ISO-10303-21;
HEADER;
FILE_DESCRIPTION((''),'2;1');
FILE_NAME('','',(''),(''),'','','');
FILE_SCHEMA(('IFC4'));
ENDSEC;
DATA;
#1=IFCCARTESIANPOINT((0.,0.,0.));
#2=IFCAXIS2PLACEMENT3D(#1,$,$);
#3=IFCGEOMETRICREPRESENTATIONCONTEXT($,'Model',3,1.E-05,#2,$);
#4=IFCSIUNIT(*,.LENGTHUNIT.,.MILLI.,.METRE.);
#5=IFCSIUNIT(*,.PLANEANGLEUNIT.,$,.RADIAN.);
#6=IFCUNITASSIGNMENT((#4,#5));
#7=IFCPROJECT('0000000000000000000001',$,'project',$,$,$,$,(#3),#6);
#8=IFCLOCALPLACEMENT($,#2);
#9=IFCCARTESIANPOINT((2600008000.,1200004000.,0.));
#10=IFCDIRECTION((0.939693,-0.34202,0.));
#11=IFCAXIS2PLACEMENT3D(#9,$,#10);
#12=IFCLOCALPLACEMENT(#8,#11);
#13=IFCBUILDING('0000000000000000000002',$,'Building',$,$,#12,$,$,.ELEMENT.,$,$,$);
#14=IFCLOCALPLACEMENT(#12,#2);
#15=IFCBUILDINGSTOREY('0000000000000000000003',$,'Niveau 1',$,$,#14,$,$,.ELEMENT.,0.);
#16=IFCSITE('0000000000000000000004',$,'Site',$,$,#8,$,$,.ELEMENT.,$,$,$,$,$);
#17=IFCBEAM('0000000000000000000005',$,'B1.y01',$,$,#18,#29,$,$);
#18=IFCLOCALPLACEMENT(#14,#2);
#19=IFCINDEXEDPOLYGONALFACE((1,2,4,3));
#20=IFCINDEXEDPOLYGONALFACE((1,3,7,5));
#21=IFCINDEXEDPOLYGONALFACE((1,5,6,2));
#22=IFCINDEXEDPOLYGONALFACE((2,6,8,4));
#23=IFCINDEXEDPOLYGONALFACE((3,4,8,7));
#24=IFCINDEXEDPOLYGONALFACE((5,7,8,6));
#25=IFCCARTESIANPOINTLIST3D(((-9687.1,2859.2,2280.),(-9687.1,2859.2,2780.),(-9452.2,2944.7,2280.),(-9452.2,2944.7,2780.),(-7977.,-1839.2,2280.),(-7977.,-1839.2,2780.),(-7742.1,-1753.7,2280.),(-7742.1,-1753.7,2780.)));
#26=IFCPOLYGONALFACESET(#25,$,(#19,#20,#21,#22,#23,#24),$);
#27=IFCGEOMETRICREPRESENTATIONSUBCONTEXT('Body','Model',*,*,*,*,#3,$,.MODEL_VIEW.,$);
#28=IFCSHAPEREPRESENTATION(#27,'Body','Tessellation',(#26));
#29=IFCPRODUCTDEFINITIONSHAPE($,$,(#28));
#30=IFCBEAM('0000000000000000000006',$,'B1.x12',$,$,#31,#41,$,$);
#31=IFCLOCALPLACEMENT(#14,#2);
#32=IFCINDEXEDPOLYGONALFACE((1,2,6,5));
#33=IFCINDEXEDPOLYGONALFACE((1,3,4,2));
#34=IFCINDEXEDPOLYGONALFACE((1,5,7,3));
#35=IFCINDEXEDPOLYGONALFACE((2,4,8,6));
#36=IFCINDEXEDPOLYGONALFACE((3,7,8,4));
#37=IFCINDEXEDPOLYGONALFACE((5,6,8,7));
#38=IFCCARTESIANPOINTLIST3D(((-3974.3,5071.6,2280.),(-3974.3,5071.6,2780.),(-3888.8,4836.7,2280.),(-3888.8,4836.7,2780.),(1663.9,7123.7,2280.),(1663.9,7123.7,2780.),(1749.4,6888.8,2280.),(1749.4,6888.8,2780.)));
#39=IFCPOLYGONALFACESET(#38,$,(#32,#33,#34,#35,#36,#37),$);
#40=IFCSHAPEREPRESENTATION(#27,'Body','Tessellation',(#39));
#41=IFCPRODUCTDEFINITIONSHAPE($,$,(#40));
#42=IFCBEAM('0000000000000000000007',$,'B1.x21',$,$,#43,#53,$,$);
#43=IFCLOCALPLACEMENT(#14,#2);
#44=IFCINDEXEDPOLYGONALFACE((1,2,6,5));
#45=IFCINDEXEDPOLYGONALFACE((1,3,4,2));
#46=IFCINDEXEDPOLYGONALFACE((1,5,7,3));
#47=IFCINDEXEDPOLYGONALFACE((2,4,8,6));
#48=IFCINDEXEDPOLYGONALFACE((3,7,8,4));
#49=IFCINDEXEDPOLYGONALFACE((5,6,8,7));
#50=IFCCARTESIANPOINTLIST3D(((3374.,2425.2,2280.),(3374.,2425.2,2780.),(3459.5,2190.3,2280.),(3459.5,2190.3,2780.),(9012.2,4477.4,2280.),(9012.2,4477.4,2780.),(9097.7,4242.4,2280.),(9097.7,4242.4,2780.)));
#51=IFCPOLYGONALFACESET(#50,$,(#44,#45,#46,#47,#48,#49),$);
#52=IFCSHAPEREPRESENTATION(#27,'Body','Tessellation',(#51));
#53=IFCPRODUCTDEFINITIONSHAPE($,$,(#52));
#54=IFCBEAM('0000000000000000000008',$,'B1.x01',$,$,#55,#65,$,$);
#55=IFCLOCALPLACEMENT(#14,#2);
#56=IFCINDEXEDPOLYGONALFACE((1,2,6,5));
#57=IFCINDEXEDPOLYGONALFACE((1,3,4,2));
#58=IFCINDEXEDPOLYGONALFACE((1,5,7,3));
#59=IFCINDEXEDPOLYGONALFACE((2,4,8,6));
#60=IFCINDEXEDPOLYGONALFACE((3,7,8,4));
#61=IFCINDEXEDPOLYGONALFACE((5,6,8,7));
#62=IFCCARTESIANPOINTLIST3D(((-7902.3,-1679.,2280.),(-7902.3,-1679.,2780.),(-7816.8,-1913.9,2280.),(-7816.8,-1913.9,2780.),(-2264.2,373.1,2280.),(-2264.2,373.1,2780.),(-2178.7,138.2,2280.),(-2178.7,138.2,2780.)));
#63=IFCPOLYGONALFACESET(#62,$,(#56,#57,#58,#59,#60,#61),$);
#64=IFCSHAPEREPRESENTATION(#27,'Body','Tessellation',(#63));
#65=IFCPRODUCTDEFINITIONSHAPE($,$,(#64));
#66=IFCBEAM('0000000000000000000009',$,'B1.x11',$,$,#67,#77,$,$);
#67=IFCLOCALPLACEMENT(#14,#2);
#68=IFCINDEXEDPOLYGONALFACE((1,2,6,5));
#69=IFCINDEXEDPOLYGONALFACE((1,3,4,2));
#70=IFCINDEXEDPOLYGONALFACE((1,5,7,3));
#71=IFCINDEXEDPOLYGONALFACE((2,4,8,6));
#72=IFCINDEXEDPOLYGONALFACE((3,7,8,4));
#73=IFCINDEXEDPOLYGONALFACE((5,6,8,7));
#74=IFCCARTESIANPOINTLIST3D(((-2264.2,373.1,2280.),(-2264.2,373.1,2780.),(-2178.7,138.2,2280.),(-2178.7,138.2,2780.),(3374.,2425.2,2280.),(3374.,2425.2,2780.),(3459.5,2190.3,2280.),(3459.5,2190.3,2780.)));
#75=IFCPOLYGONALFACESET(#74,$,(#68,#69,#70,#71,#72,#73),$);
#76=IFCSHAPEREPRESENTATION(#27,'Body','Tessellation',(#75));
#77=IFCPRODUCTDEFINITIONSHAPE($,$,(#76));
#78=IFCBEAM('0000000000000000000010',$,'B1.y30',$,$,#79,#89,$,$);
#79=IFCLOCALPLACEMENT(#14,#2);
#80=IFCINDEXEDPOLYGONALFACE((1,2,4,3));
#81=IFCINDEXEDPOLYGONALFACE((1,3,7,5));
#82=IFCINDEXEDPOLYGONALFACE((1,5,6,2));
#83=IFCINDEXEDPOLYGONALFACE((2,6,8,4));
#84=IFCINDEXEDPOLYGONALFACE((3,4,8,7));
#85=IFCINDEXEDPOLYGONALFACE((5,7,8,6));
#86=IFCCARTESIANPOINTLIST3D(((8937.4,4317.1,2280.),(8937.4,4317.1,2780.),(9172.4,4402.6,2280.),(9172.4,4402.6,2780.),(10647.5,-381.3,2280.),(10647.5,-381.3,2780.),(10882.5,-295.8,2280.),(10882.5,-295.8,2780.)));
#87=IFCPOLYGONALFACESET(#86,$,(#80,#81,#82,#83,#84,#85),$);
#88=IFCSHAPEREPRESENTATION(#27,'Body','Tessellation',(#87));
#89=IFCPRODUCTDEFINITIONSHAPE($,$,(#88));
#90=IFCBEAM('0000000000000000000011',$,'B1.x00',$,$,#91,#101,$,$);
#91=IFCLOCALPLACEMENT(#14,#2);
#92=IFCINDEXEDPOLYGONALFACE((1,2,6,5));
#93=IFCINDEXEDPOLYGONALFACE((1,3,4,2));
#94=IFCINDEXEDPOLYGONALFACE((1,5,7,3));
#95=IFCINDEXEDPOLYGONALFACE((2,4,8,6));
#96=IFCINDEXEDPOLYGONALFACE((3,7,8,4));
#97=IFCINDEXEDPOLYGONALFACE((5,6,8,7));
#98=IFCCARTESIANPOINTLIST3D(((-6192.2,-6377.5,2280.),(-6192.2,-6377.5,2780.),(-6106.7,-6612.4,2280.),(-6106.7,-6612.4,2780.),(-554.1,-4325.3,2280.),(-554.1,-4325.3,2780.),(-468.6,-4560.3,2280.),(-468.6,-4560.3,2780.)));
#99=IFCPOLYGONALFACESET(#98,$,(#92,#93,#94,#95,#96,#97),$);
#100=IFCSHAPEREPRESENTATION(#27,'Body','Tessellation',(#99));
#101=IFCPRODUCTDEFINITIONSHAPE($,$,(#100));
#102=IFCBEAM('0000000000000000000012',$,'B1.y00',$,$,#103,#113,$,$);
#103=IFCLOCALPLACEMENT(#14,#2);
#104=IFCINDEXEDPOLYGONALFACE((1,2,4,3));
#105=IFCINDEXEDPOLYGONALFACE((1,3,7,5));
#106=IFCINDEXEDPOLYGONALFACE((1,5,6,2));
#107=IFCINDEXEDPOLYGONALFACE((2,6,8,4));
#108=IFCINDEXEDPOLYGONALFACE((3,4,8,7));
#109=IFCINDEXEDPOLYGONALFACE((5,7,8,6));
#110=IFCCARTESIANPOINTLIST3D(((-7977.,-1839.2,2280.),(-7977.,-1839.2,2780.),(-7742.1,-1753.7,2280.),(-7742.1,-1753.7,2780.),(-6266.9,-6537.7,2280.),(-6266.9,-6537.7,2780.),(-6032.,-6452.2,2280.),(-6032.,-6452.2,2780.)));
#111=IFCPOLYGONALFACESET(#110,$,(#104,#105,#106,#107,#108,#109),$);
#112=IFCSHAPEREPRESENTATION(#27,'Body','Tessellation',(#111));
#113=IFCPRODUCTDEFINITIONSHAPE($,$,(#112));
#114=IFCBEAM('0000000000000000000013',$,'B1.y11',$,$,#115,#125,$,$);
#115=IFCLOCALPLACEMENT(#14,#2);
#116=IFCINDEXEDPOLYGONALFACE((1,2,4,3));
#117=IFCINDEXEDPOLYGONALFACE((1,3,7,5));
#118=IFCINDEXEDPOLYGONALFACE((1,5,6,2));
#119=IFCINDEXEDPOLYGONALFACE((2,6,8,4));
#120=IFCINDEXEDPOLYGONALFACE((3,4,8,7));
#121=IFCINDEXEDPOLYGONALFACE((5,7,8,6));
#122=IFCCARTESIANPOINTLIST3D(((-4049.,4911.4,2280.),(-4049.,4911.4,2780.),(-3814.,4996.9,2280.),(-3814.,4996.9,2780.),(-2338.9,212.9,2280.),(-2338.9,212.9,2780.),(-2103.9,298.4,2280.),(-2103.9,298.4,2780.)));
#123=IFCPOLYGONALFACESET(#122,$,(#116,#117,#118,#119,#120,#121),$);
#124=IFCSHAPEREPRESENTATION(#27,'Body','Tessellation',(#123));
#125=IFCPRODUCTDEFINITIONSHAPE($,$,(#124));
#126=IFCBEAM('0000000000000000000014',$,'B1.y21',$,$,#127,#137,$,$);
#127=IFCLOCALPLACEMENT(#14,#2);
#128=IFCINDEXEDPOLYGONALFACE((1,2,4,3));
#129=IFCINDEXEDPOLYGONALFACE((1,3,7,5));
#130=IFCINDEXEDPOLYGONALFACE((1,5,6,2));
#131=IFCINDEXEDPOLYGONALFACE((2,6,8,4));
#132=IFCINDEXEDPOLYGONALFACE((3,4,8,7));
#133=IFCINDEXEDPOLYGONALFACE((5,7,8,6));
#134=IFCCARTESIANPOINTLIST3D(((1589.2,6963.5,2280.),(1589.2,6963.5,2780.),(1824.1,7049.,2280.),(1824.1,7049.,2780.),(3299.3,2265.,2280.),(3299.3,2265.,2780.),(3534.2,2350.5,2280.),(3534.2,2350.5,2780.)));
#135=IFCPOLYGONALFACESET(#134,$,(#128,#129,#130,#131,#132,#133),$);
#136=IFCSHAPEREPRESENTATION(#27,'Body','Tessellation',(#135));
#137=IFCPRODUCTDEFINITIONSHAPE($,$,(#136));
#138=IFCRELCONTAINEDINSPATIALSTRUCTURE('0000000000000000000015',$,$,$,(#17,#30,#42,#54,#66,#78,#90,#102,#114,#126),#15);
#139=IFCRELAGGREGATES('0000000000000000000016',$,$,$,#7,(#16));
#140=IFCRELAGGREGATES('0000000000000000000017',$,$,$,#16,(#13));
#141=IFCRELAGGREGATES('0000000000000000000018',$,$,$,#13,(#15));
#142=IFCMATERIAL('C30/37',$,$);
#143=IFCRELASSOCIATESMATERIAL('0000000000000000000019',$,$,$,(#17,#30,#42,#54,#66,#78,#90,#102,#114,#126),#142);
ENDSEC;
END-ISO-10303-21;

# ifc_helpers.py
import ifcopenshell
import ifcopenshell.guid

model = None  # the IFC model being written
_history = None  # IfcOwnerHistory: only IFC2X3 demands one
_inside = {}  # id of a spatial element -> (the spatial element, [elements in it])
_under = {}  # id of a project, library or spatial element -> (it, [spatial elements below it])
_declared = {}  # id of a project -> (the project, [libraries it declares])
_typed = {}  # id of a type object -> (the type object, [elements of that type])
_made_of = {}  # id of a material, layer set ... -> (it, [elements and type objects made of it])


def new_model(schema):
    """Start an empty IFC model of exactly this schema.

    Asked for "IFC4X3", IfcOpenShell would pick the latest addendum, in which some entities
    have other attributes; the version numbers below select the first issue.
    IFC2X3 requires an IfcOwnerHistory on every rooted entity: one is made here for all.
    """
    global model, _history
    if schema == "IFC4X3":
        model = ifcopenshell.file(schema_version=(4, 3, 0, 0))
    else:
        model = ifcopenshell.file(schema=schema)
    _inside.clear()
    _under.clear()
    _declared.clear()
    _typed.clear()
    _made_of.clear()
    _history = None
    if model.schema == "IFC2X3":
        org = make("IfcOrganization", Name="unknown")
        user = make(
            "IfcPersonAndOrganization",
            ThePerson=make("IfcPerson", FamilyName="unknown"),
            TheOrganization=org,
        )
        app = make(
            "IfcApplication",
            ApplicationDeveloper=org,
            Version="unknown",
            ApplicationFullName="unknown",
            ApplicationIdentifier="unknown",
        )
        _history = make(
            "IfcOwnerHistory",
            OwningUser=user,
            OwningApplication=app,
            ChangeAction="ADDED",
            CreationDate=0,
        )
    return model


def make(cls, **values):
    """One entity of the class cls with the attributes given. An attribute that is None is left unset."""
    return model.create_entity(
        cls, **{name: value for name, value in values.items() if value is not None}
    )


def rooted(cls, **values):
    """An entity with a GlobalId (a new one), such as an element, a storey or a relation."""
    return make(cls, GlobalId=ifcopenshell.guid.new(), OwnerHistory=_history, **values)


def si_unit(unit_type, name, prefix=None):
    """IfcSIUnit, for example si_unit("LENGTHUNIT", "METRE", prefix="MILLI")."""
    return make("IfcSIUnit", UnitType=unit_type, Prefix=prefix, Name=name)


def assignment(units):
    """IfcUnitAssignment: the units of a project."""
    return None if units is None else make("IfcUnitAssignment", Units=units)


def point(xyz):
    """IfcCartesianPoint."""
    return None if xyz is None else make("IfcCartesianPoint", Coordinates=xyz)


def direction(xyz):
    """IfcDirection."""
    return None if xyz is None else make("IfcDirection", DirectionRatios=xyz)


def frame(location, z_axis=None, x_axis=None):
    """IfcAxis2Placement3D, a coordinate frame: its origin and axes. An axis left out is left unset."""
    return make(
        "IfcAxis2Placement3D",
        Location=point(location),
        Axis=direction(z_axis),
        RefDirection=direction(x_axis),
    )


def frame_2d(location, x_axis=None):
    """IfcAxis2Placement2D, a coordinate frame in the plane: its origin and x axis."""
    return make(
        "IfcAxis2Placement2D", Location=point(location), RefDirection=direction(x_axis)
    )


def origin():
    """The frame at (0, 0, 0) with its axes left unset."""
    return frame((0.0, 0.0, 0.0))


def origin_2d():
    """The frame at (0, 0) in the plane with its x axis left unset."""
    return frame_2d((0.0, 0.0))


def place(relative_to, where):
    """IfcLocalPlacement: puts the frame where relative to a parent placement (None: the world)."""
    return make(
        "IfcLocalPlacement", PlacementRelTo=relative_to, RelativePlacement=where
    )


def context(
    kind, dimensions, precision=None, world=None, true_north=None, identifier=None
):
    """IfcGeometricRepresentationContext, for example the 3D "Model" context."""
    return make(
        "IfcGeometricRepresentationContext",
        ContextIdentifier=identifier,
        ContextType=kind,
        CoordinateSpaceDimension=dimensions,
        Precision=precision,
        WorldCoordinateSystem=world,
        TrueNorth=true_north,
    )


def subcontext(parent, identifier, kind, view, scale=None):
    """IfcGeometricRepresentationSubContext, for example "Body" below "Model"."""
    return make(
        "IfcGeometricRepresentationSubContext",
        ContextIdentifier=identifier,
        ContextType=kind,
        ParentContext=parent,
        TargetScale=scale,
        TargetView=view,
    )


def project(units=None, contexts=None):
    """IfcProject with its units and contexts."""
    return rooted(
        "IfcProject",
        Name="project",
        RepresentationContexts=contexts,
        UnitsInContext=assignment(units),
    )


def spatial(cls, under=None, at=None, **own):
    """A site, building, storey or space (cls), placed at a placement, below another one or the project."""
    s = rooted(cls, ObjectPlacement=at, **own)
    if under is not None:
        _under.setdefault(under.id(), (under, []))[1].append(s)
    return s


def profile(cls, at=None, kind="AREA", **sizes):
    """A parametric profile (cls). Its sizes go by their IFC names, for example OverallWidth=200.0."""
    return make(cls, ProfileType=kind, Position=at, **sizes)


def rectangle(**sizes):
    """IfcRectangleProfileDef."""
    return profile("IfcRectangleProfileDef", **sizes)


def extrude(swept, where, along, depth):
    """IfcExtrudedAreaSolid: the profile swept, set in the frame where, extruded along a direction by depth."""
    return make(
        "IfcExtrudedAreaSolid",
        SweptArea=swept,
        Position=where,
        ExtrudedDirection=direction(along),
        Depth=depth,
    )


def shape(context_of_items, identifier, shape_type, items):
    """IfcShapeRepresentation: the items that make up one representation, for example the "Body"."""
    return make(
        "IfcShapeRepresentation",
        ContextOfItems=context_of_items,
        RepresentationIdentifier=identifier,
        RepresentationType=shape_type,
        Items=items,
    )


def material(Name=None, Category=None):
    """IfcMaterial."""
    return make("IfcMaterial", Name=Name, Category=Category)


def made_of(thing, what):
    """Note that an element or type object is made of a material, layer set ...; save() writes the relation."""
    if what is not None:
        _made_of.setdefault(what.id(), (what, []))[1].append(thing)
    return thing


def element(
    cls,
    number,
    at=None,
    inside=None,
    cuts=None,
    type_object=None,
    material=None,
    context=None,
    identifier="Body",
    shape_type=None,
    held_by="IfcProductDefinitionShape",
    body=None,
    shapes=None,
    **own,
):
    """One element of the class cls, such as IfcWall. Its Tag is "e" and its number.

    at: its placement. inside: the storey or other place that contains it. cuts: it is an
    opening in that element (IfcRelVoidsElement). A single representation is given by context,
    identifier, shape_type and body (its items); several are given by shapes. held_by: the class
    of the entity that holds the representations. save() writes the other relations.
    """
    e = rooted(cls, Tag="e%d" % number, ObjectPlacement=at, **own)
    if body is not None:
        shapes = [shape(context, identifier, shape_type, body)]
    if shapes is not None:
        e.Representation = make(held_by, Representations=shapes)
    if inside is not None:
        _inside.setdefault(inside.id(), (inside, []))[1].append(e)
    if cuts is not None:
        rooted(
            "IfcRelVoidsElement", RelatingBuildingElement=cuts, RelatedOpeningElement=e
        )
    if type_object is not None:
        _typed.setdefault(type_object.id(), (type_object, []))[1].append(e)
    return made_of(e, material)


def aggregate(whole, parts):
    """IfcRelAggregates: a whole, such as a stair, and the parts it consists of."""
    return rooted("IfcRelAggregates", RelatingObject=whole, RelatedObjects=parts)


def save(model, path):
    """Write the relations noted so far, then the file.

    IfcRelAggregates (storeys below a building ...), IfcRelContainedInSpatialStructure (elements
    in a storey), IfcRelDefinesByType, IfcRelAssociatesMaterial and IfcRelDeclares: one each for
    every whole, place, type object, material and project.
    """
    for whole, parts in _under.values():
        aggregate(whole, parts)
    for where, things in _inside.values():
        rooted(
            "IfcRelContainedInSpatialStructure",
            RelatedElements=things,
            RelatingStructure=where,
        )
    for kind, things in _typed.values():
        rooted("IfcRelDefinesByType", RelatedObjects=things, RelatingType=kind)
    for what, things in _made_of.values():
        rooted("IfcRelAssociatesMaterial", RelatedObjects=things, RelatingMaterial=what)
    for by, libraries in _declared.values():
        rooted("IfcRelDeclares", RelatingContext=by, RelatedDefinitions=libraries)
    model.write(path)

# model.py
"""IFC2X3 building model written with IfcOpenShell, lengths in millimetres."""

from ifc_helpers import new_model, si_unit, frame, origin, origin_2d, place, context, subcontext, project, spatial, rectangle, extrude, material, element, save


model = new_model("IFC2X3")

# Units and contexts
model_context = context("Model", 3, precision=1e-05, world=origin())
body_context = subcontext(model_context, "Body", "Model", "MODEL_VIEW")
ifc_project = project(units=[si_unit("LENGTHUNIT", "METRE", prefix="MILLI"), si_unit("PLANEANGLEUNIT", "RADIAN")], contexts=[model_context])

# Site, building, storey
site_placement = place(None, origin())
site = spatial("IfcSite", under=ifc_project, at=site_placement, Name="Site", CompositionType="ELEMENT")
building_placement = place(site_placement, frame((2600008000.0, 1200004000.0, 0.0), x_axis=(0.939693, -0.34202, 0.0)))
building = spatial("IfcBuilding", under=site, at=building_placement, Name="Building", CompositionType="ELEMENT")
storey_placement = place(building_placement, origin())
storey = spatial("IfcBuildingStorey", under=building, at=storey_placement, Name="Niveau 1", CompositionType="ELEMENT", Elevation=0.0)

# Shared definitions
ifc_material = material(Name="C30/37")

# Beams
beam_1_placement = place(storey_placement, frame((-7859.6, -1796.5, 2530.0), z_axis=(-0.34202, 0.939693, 0.0), x_axis=(-0.939693, -0.34202, 0.0)))
element("IfcBeam", 1, at=beam_1_placement, inside=storey, material=ifc_material, Name="B1.y01", context=body_context, shape_type="SweptSolid", body=[
    extrude(rectangle(XDim=250.0, YDim=500.0, at=origin_2d()), origin(), (0.0, 0.0, 1.0), 5000.0),
])
for number, where, z_axis, x_axis, name in (
    (2, (-3931.5, 4954.1, 2530.0), (0.939693, 0.34202, 0.0), (-0.34202, 0.939693, 0.0), "B1.x12"),
    (3, (3416.8, 2307.8, 2530.0), (0.939693, 0.34202, 0.0), (-0.34202, 0.939693, 0.0), "B1.x21"),
    (4, (-7859.6, -1796.5, 2530.0), (0.939693, 0.34202, 0.0), (-0.34202, 0.939693, 0.0), "B1.x01"),
    (5, (-2221.4, 255.7, 2530.0), (0.939693, 0.34202, 0.0), (-0.34202, 0.939693, 0.0), "B1.x11"),
):
    element("IfcBeam", number, at=place(storey_placement, frame(where, z_axis=z_axis, x_axis=x_axis)), inside=storey, material=ifc_material, Name=name, context=body_context, shape_type="SweptSolid", body=[
        extrude(rectangle(XDim=250.0, YDim=500.0, at=origin_2d()), origin(), (0.0, 0.0, 1.0), 6000.0),
    ])
beam_2_placement = place(storey_placement, frame((10765.0, -338.6, 2530.0), z_axis=(-0.34202, 0.939693, 0.0), x_axis=(-0.939693, -0.34202, 0.0)))
element("IfcBeam", 6, at=beam_2_placement, inside=storey, material=ifc_material, Name="B1.y30", context=body_context, shape_type="SweptSolid", body=[
    extrude(rectangle(XDim=250.0, YDim=500.0, at=origin_2d()), origin(), (0.0, 0.0, 1.0), 5000.0),
])
beam_3_placement = place(storey_placement, frame((-6149.5, -6494.9, 2530.0), z_axis=(0.939693, 0.34202, 0.0), x_axis=(-0.34202, 0.939693, 0.0)))
element("IfcBeam", 7, at=beam_3_placement, inside=storey, material=ifc_material, Name="B1.x00", context=body_context, shape_type="SweptSolid", body=[
    extrude(rectangle(XDim=250.0, YDim=500.0, at=origin_2d()), origin(), (0.0, 0.0, 1.0), 6000.0),
])
for number, where, z_axis, x_axis, name in (
    (8, (-6149.5, -6494.9, 2530.0), (-0.34202, 0.939693, 0.0), (-0.939693, -0.34202, 0.0), "B1.y00"),
    (9, (-2221.4, 255.7, 2530.0), (-0.34202, 0.939693, 0.0), (-0.939693, -0.34202, 0.0), "B1.y11"),
    (10, (3416.8, 2307.8, 2530.0), (-0.34202, 0.939693, 0.0), (-0.939693, -0.34202, 0.0), "B1.y21"),
):
    element("IfcBeam", number, at=place(storey_placement, frame(where, z_axis=z_axis, x_axis=x_axis)), inside=storey, material=ifc_material, Name=name, context=body_context, shape_type="SweptSolid", body=[
        extrude(rectangle(XDim=250.0, YDim=500.0, at=origin_2d()), origin(), (0.0, 0.0, 1.0), 5000.0),
    ])

save(model, "model.ifc")
